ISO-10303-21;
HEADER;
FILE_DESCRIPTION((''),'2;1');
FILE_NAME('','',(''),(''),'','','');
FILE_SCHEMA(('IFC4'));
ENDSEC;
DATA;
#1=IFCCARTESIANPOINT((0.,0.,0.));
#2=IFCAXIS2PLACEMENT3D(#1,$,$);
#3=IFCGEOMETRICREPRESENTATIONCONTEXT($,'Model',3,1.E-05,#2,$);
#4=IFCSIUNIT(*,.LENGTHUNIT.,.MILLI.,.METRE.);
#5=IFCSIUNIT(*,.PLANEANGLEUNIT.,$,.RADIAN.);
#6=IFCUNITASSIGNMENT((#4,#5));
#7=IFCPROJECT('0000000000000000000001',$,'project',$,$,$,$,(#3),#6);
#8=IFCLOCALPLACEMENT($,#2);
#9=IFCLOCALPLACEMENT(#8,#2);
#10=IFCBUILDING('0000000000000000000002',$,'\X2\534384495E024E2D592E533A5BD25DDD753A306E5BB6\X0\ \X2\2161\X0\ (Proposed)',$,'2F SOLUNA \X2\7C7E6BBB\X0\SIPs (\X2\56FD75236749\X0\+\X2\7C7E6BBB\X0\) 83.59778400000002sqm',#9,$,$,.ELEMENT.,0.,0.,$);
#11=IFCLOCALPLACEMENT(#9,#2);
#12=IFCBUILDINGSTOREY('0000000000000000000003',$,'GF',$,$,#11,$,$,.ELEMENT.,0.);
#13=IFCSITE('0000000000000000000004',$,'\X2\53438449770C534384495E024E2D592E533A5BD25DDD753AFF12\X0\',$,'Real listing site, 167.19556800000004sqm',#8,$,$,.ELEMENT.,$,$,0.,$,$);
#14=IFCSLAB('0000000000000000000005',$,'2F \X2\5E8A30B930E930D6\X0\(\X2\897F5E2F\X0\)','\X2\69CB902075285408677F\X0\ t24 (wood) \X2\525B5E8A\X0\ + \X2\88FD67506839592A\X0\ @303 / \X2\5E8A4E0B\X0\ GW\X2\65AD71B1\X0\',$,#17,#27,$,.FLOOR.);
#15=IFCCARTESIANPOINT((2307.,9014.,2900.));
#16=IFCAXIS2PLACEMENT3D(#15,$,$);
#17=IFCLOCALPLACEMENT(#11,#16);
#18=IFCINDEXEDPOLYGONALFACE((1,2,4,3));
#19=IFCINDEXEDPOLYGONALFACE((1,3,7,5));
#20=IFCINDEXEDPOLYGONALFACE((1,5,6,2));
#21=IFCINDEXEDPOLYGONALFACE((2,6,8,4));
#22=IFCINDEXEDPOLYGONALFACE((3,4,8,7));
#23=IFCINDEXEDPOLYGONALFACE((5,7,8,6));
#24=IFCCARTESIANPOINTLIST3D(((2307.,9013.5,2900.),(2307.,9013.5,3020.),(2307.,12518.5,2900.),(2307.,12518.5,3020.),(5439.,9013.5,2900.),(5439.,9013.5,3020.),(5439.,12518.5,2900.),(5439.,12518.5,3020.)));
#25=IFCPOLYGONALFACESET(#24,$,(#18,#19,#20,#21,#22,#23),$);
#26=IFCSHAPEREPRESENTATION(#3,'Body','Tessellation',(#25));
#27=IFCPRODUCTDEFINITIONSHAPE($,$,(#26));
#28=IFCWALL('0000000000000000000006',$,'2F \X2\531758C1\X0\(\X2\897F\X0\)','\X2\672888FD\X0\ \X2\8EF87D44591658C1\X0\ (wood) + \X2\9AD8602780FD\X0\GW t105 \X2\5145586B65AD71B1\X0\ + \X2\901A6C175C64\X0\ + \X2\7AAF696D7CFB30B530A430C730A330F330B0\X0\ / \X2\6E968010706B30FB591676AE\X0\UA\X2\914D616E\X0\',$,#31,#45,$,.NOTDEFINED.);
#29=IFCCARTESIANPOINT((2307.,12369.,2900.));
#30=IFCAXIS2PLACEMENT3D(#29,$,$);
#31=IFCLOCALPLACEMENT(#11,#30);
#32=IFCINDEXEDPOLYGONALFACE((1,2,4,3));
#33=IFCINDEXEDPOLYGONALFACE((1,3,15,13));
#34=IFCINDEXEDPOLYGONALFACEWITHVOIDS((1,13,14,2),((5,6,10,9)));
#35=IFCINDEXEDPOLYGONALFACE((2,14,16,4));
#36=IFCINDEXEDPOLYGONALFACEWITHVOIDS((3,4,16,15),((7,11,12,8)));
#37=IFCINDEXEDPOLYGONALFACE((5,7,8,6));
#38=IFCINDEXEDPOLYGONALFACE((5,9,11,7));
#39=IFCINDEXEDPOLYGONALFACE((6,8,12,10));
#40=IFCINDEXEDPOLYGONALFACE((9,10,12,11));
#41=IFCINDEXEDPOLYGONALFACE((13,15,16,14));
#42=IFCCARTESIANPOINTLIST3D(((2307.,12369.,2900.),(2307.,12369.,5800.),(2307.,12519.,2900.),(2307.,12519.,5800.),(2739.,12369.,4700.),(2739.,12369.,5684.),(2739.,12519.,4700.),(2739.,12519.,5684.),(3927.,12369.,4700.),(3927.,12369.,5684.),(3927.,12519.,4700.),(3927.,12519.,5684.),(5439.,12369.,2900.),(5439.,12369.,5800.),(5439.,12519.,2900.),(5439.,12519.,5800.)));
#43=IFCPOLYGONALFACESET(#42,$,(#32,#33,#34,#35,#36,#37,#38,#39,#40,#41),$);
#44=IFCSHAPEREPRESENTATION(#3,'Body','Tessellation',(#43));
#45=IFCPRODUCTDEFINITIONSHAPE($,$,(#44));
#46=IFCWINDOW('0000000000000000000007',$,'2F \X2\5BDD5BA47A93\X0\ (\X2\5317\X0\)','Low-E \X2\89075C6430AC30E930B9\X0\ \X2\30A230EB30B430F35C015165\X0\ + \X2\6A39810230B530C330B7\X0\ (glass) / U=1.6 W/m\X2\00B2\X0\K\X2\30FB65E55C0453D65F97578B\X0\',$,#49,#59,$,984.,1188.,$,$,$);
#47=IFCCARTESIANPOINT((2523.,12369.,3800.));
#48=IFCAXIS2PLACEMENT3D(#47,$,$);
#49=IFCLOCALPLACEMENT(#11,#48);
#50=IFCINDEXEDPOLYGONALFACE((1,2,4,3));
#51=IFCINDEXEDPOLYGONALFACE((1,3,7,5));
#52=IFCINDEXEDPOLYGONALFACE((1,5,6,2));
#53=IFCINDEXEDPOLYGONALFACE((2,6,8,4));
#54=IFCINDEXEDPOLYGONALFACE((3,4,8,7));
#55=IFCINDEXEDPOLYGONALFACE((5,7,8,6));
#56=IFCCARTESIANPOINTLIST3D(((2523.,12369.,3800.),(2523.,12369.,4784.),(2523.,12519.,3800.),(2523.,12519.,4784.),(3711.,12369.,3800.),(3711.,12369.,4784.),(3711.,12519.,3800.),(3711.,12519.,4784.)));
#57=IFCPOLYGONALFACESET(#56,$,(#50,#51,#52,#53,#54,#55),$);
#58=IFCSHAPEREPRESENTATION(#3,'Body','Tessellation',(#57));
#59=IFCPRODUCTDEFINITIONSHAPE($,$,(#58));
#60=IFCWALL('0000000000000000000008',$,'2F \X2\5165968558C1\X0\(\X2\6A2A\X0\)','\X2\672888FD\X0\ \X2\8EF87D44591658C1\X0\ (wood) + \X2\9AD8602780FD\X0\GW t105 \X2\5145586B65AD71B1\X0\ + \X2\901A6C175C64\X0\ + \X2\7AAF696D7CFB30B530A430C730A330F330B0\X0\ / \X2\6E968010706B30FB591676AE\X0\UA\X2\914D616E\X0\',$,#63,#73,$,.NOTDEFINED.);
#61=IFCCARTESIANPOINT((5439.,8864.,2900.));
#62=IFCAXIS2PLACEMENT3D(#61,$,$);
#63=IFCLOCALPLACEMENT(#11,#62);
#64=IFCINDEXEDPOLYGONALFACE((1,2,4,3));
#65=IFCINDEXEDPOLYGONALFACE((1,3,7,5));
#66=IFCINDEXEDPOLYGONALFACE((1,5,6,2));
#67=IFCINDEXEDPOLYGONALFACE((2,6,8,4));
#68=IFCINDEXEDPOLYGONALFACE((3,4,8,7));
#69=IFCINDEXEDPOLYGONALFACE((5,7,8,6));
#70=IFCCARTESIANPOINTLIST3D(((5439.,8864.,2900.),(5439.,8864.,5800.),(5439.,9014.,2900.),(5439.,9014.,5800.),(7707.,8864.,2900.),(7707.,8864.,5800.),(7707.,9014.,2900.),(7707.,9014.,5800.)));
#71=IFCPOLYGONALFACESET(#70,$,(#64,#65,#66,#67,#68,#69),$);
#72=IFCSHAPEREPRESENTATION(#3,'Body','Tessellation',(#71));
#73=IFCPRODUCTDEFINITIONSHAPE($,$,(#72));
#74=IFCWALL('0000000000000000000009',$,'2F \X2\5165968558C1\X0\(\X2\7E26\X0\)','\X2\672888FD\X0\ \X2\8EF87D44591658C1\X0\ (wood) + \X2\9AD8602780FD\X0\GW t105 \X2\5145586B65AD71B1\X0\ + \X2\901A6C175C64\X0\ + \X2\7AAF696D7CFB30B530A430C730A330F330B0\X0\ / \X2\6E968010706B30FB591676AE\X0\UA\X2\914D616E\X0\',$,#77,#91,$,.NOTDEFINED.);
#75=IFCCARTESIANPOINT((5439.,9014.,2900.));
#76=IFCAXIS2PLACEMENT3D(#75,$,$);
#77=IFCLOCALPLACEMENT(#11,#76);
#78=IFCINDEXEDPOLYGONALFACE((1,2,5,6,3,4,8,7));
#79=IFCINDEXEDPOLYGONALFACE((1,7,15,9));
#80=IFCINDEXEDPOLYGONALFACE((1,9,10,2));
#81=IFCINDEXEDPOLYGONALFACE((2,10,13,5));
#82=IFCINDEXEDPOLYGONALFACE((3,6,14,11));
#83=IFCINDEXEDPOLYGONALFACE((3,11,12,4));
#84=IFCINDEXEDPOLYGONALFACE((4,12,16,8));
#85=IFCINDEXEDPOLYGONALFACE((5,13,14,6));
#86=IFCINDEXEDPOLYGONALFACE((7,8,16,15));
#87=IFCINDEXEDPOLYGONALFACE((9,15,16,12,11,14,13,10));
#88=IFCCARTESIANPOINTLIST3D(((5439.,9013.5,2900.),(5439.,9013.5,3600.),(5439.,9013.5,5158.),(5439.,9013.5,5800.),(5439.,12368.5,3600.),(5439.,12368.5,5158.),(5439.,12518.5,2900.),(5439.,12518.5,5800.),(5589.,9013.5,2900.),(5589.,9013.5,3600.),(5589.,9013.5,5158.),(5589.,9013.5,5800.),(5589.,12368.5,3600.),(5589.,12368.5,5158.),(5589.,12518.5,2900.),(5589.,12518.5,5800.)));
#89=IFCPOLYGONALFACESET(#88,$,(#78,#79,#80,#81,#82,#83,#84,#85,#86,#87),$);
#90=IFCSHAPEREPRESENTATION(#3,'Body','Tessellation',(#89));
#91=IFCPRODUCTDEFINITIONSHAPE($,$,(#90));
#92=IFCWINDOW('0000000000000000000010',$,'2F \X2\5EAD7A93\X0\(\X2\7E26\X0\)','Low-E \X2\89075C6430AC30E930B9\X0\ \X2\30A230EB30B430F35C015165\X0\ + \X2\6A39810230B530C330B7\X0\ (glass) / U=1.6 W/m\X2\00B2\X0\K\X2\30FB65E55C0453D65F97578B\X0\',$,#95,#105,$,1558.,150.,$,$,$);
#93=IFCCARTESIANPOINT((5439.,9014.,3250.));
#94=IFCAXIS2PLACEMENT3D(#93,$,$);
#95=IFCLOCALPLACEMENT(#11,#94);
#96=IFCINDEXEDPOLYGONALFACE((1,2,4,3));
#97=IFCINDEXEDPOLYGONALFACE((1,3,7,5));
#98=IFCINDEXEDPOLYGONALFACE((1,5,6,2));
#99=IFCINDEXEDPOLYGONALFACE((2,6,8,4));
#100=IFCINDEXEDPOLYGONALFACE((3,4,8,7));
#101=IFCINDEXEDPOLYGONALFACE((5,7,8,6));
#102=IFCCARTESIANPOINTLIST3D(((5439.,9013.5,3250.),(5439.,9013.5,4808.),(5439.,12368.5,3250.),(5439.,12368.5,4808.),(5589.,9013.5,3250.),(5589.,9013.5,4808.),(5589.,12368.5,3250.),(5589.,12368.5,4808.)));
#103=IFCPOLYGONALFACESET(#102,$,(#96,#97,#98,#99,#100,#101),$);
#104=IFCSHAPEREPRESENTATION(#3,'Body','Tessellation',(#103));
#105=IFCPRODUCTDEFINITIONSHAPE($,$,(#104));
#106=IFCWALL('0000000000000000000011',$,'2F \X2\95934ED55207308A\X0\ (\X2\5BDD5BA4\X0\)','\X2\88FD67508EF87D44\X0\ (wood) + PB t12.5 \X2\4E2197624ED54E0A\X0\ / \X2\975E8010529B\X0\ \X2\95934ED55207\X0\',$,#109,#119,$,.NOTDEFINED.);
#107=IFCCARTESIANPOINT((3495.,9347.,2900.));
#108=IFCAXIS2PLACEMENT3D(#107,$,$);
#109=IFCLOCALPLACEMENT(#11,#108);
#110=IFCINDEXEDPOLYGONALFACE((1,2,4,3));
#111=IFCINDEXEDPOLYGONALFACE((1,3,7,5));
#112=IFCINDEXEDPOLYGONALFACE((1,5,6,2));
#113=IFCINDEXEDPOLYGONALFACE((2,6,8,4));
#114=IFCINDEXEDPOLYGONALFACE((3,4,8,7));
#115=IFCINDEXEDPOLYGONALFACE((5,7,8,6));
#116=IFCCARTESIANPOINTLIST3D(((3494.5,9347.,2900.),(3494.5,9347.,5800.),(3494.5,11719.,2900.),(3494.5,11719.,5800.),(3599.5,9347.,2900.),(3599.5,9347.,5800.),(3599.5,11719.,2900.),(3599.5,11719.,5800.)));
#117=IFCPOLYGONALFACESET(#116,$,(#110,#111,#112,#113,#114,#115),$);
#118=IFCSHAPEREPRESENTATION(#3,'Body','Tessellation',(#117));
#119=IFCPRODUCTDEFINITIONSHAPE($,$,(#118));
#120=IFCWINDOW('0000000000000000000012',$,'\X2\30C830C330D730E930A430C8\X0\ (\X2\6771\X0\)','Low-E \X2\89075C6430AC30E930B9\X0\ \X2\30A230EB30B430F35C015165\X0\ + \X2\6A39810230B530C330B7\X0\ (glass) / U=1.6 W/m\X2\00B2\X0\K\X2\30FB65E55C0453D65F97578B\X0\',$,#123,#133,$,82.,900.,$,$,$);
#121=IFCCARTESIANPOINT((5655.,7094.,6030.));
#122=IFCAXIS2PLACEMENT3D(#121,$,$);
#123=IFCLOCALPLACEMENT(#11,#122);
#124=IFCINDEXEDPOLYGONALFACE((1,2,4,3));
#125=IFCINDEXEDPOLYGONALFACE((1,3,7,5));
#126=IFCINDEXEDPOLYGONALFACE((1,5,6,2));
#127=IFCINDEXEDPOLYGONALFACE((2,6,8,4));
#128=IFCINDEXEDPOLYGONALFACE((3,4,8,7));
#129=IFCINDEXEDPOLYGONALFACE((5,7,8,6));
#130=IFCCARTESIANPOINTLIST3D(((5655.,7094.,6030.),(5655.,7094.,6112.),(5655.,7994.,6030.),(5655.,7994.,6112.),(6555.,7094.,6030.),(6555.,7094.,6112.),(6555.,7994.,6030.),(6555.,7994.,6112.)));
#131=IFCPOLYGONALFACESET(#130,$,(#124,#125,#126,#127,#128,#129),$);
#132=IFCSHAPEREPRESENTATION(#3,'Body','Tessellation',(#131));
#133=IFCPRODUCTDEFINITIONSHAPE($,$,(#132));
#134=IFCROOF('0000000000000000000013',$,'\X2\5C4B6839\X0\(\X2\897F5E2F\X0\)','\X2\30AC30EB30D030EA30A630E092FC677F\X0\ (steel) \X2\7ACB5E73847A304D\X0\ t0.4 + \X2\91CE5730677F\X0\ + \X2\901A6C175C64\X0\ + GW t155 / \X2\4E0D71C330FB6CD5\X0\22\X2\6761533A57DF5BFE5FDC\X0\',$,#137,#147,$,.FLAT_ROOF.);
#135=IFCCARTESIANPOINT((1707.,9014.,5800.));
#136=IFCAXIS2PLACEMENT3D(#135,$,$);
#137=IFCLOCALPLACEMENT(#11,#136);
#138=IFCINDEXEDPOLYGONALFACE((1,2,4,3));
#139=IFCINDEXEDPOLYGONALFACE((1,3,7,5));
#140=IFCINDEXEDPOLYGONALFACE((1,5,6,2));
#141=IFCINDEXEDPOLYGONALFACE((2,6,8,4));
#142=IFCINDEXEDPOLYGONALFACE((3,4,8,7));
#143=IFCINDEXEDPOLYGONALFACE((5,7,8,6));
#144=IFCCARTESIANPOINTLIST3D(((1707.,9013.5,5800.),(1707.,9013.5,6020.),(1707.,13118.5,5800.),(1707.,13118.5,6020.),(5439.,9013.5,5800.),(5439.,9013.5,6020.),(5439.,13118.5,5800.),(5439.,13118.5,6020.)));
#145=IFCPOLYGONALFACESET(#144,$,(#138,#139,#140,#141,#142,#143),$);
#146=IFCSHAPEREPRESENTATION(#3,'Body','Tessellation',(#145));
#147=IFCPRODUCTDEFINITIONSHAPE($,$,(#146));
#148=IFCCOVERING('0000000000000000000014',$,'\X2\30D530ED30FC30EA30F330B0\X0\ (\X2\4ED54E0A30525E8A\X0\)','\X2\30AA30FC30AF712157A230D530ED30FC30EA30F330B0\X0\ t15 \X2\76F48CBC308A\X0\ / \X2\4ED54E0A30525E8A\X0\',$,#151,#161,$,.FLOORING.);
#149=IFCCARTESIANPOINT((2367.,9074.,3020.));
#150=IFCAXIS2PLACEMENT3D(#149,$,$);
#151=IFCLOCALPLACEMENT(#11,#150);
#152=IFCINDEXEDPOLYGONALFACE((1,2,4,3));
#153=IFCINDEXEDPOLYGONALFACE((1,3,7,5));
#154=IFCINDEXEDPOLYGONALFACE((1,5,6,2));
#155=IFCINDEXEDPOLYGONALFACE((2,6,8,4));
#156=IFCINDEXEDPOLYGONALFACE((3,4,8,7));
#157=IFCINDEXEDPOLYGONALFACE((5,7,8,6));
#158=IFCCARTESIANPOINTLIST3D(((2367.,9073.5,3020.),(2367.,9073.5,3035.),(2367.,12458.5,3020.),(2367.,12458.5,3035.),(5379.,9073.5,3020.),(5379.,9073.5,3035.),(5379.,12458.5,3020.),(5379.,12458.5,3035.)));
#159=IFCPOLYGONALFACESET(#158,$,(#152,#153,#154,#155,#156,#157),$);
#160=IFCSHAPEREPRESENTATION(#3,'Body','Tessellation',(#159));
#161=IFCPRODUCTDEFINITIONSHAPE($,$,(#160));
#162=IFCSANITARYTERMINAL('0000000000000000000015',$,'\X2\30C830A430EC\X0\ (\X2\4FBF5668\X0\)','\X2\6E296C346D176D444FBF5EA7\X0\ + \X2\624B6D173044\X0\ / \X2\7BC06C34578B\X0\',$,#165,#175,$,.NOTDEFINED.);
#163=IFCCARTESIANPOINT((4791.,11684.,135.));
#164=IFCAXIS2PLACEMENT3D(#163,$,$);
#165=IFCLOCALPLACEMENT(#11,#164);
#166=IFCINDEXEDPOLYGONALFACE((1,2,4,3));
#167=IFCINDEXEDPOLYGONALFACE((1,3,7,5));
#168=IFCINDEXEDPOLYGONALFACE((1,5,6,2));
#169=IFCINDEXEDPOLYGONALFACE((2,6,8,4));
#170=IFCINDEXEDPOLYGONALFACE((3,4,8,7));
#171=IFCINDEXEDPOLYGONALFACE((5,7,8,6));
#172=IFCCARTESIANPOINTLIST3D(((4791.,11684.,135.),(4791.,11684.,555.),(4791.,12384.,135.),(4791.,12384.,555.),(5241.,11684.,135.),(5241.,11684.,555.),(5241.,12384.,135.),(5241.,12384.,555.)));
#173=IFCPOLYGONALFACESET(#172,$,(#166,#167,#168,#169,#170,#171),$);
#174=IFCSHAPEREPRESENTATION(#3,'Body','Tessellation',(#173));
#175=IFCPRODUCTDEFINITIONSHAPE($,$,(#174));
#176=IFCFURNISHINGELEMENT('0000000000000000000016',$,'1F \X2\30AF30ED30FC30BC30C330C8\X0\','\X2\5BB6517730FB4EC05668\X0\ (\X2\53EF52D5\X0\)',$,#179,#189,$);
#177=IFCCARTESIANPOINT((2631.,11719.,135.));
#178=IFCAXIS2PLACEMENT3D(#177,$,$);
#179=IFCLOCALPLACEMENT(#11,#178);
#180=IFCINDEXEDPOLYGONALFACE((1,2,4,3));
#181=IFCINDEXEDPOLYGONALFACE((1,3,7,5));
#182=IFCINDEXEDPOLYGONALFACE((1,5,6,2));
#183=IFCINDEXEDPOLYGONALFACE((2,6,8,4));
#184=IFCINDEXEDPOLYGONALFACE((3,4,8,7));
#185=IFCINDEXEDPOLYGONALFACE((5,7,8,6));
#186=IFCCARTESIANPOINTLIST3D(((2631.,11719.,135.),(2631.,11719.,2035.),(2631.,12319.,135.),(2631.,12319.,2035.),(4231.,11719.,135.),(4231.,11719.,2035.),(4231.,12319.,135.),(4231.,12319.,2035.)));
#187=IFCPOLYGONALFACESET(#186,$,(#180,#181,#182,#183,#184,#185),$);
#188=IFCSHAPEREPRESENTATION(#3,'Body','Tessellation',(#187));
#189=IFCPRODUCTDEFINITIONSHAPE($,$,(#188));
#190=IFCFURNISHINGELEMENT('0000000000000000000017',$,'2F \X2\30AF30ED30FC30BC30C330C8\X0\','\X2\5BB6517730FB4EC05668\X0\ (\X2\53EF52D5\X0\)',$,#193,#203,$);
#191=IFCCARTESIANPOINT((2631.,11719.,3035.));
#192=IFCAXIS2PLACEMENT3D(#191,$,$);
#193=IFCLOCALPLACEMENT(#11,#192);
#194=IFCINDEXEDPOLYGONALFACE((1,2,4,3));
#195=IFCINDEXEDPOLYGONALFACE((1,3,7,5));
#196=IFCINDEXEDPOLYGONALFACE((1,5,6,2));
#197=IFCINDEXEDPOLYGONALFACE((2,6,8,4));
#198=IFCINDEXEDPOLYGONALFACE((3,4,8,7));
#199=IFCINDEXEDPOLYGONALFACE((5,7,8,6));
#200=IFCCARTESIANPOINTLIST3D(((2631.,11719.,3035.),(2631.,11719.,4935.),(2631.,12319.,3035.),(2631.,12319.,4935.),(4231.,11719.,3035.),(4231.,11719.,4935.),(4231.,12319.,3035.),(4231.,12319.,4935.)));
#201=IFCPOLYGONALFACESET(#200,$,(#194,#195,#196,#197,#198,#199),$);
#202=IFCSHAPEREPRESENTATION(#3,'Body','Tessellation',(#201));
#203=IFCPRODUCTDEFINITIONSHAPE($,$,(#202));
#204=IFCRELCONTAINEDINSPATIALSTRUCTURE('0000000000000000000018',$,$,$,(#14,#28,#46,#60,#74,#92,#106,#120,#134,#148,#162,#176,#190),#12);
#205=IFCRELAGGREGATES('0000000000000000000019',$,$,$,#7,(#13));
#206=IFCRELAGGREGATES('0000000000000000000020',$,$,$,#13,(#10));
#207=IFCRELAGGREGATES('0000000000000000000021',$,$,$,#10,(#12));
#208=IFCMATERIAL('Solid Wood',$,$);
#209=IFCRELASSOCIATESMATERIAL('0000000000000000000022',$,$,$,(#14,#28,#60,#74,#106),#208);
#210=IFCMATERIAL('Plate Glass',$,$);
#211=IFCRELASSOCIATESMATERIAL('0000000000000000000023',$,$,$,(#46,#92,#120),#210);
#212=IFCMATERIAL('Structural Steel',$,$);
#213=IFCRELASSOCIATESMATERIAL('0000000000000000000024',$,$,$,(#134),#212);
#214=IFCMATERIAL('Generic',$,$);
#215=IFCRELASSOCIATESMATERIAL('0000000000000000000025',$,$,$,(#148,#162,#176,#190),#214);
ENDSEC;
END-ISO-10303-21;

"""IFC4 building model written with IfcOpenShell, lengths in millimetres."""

from ifc_helpers import new_model, si_unit, frame, frame_2d, origin, place, context, project, spatial, rectangle, extrude, material, element, fill, save


model = new_model("IFC4")

# Units and contexts
model_context = context("Model", 3, precision=1e-05, world=origin())
ifc_project = project(units=[si_unit("LENGTHUNIT", "METRE", prefix="MILLI"), si_unit("PLANEANGLEUNIT", "RADIAN")], contexts=[model_context])

# Site, building, storey
site_placement = place(None, origin())
site = spatial("IfcSite", under=ifc_project, at=site_placement, Name="千葉県千葉市中央区寒川町２", ObjectType="Real listing site, 167.19556800000004sqm", CompositionType="ELEMENT", RefElevation=0.0)
building_placement = place(site_placement, origin())
building = spatial("IfcBuilding", under=site, at=building_placement, Name="千葉市中央区寒川町の家 Ⅱ (Proposed)", ObjectType="2F SOLUNA 籾殻SIPs (国産杉+籾殻) 83.59778400000002sqm", CompositionType="ELEMENT", ElevationOfRefHeight=0.0, ElevationOfTerrain=0.0)
storey_placement = place(building_placement, origin())
storey = spatial("IfcBuildingStorey", under=building, at=storey_placement, Name="GF", CompositionType="ELEMENT", Elevation=0.0)

# Slab
ifc_material_1 = material(Name="Solid Wood")
slab_placement = place(storey_placement, frame((2307.0, 9014.0, 2900.0)))
element("IfcSlab", 1, at=slab_placement, inside=storey, material=ifc_material_1, Name="2F 床スラブ(西帯)", Description="構造用合板 t24 (wood) 剛床 + 製材根太 @303 / 床下 GW断熱", PredefinedType="FLOOR", context=model_context, shape_type="SweptSolid", body=[
    extrude(rectangle(XDim=3132.0, YDim=3505.0, at=frame_2d((1566.0, 1752.0))), frame((2307.0, 9014.0, 2900.0)), (0.0, 0.0, 1.0), 120.0),
])

# Wall, opening, window
wall_1_placement = place(storey_placement, frame((2307.0, 12369.0, 2900.0)))
wall_1 = element("IfcWall", 2, at=wall_1_placement, inside=storey, material=ifc_material_1, Name="2F 北壁(西)", Description="木製 軸組外壁 (wood) + 高性能GW t105 充填断熱 + 通気層 + 窯業系サイディング / 準耐火・外皮UA配慮", PredefinedType="NOTDEFINED", context=model_context, shape_type="SweptSolid", body=[
    extrude(rectangle(XDim=3132.0, YDim=150.0, at=frame_2d((1566.0, 75.0))), frame((2307.0, 12369.0, 2900.0)), (0.0, 0.0, 1.0), 2900.0),
])
opening_1_placement = place(storey_placement, frame((2523.0, 12369.0, 3800.0)))
opening_1 = element("IfcOpeningElement", 3, at=opening_1_placement, cuts=wall_1, PredefinedType="NOTDEFINED", context=model_context, shape_type="SweptSolid", body=[
    extrude(rectangle(XDim=1188.0, YDim=150.0, at=frame_2d((594.0, 75.0))), frame((2523.0, 12369.0, 3800.0)), (0.0, 0.0, 1.0), 984.0),
])
ifc_material_2 = material(Name="Plate Glass")
window_1_placement = place(storey_placement, frame((2523.0, 12369.0, 3800.0)))
window_1 = element("IfcWindow", 4, at=window_1_placement, inside=storey, material=ifc_material_2, Name="2F 寝室窓 (北)", Description="Low-E 複層ガラス アルゴン封入 + 樹脂サッシ (glass) / U=1.6 W/m²K・日射取得型", OverallHeight=984.0, OverallWidth=1188.0, context=model_context, shape_type="SweptSolid", body=[
    extrude(rectangle(XDim=1188.0, YDim=150.0, at=frame_2d((594.0, 75.0))), frame((2523.0, 12369.0, 3800.0)), (0.0, 0.0, 1.0), 984.0),
])
fill(opening_1, window_1)

# Wall
wall_2_placement = place(storey_placement, frame((5439.0, 8864.0, 2900.0)))
element("IfcWall", 5, at=wall_2_placement, inside=storey, material=ifc_material_1, Name="2F 入隅壁(横)", Description="木製 軸組外壁 (wood) + 高性能GW t105 充填断熱 + 通気層 + 窯業系サイディング / 準耐火・外皮UA配慮", PredefinedType="NOTDEFINED", context=model_context, shape_type="SweptSolid", body=[
    extrude(rectangle(XDim=2268.0, YDim=150.0, at=frame_2d((1134.0, 75.0))), frame((5439.0, 8864.0, 2900.0)), (0.0, 0.0, 1.0), 2900.0),
])

# Wall, opening, window
wall_3_placement = place(storey_placement, frame((5439.0, 9014.0, 2900.0)))
wall_3 = element("IfcWall", 6, at=wall_3_placement, inside=storey, material=ifc_material_1, Name="2F 入隅壁(縦)", Description="木製 軸組外壁 (wood) + 高性能GW t105 充填断熱 + 通気層 + 窯業系サイディング / 準耐火・外皮UA配慮", PredefinedType="NOTDEFINED", context=model_context, shape_type="SweptSolid", body=[
    extrude(rectangle(XDim=150.0, YDim=3505.0, at=frame_2d((75.0, 1752.0))), frame((5439.0, 9014.0, 2900.0)), (0.0, 0.0, 1.0), 2900.0),
])
opening_2_placement = place(storey_placement, frame((5439.0, 9014.0, 3250.0)))
opening_2 = element("IfcOpeningElement", 7, at=opening_2_placement, cuts=wall_3, PredefinedType="NOTDEFINED", context=model_context, shape_type="SweptSolid", body=[
    extrude(rectangle(XDim=150.0, YDim=3355.0, at=frame_2d((75.0, 1677.0))), frame((5439.0, 9014.0, 3250.0)), (0.0, 0.0, 1.0), 1558.0),
])
window_2_placement = place(storey_placement, frame((5439.0, 9014.0, 3250.0)))
window_2 = element("IfcWindow", 8, at=window_2_placement, inside=storey, material=ifc_material_2, Name="2F 庭窓(縦)", Description="Low-E 複層ガラス アルゴン封入 + 樹脂サッシ (glass) / U=1.6 W/m²K・日射取得型", OverallHeight=1558.0, OverallWidth=150.0, context=model_context, shape_type="SweptSolid", body=[
    extrude(rectangle(XDim=150.0, YDim=3355.0, at=frame_2d((75.0, 1677.0))), frame((5439.0, 9014.0, 3250.0)), (0.0, 0.0, 1.0), 1558.0),
])
fill(opening_2, window_2)

# Wall
wall_4_placement = place(storey_placement, frame((3495.0, 9347.0, 2900.0)))
element("IfcWall", 9, at=wall_4_placement, inside=storey, material=ifc_material_1, Name="2F 間仕切り (寝室)", Description="製材軸組 (wood) + PB t12.5 両面仕上 / 非耐力 間仕切", PredefinedType="NOTDEFINED", context=model_context, shape_type="SweptSolid", body=[
    extrude(rectangle(XDim=105.0, YDim=2372.0, at=frame_2d((52.0, 1186.0))), frame((3495.0, 9347.0, 2900.0)), (0.0, 0.0, 1.0), 2900.0),
])

# Window
window_3_placement = place(storey_placement, frame((5655.0, 7094.0, 6030.0)))
element("IfcWindow", 10, at=window_3_placement, inside=storey, material=ifc_material_2, Name="トップライト (東)", Description="Low-E 複層ガラス アルゴン封入 + 樹脂サッシ (glass) / U=1.6 W/m²K・日射取得型", OverallHeight=82.0, OverallWidth=900.0, context=model_context, shape_type="SweptSolid", body=[
    extrude(rectangle(XDim=900.0, YDim=900.0, at=frame_2d((450.0, 450.0))), frame((5655.0, 7094.0, 6030.0)), (0.0, 0.0, 1.0), 82.0),
])

# Roof
ifc_material_3 = material(Name="Structural Steel")
for number, where, name in (
    (11, (1707.0, 9014.0, 5800.0), "屋根(西帯)"),
):
    element("IfcRoof", number, at=place(storey_placement, frame(where)), inside=storey, material=ifc_material_3, Name=name, Description="ガルバリウム鋼板 (steel) 立平葺き t0.4 + 野地板 + 通気層 + GW t155 / 不燃・法22条区域対応", PredefinedType="FLAT_ROOF", context=model_context, shape_type="SweptSolid", body=[
        extrude(rectangle(XDim=3732.0, YDim=4105.0, at=frame_2d((1866.0, 2052.0))), frame((1707.0, 9014.0, 5800.0)), (0.0, 0.0, 1.0), 220.0),
    ])

# Covering
ifc_material_4 = material(Name="Generic")
covering_placement = place(storey_placement, frame((2367.0, 9074.0, 3020.0)))
element("IfcCovering", 12, at=covering_placement, inside=storey, material=ifc_material_4, Name="フローリング (仕上げ床)", Description="オーク無垢フローリング t15 直貼り / 仕上げ床", PredefinedType="FLOORING", context=model_context, shape_type="SweptSolid", body=[
    extrude(rectangle(XDim=3012.0, YDim=3385.0, at=frame_2d((1506.0, 1692.0))), frame((2367.0, 9074.0, 3020.0)), (0.0, 0.0, 1.0), 15.0),
])

# Sanitary terminal
sanitary_terminal_placement = place(storey_placement, frame((4791.0, 11684.0, 135.0)))
element("IfcSanitaryTerminal", 13, at=sanitary_terminal_placement, inside=storey, material=ifc_material_4, Name="トイレ (便器)", Description="温水洗浄便座 + 手洗い / 節水型", PredefinedType="NOTDEFINED", context=model_context, shape_type="SweptSolid", body=[
    extrude(rectangle(XDim=450.0, YDim=700.0, at=frame_2d((225.0, 350.0))), frame((4791.0, 11684.0, 135.0)), (0.0, 0.0, 1.0), 420.0),
])

# Furnishing elements
furnishing_1_placement = place(storey_placement, frame((2631.0, 11719.0, 135.0)))
element("IfcFurnishingElement", 14, at=furnishing_1_placement, inside=storey, material=ifc_material_4, Name="1F クローゼット", Description="家具・什器 (可動)", context=model_context, shape_type="SweptSolid", body=[
    extrude(rectangle(XDim=1600.0, YDim=600.0, at=frame_2d((800.0, 300.0))), frame((2631.0, 11719.0, 135.0)), (0.0, 0.0, 1.0), 1900.0),
])
furnishing_2_placement = place(storey_placement, frame((2631.0, 11719.0, 3035.0)))
element("IfcFurnishingElement", 15, at=furnishing_2_placement, inside=storey, material=ifc_material_4, Name="2F クローゼット", Description="家具・什器 (可動)", context=model_context, shape_type="SweptSolid", body=[
    extrude(rectangle(XDim=1600.0, YDim=600.0, at=frame_2d((800.0, 300.0))), frame((2631.0, 11719.0, 3035.0)), (0.0, 0.0, 1.0), 1900.0),
])

save(model, "model.ifc")
